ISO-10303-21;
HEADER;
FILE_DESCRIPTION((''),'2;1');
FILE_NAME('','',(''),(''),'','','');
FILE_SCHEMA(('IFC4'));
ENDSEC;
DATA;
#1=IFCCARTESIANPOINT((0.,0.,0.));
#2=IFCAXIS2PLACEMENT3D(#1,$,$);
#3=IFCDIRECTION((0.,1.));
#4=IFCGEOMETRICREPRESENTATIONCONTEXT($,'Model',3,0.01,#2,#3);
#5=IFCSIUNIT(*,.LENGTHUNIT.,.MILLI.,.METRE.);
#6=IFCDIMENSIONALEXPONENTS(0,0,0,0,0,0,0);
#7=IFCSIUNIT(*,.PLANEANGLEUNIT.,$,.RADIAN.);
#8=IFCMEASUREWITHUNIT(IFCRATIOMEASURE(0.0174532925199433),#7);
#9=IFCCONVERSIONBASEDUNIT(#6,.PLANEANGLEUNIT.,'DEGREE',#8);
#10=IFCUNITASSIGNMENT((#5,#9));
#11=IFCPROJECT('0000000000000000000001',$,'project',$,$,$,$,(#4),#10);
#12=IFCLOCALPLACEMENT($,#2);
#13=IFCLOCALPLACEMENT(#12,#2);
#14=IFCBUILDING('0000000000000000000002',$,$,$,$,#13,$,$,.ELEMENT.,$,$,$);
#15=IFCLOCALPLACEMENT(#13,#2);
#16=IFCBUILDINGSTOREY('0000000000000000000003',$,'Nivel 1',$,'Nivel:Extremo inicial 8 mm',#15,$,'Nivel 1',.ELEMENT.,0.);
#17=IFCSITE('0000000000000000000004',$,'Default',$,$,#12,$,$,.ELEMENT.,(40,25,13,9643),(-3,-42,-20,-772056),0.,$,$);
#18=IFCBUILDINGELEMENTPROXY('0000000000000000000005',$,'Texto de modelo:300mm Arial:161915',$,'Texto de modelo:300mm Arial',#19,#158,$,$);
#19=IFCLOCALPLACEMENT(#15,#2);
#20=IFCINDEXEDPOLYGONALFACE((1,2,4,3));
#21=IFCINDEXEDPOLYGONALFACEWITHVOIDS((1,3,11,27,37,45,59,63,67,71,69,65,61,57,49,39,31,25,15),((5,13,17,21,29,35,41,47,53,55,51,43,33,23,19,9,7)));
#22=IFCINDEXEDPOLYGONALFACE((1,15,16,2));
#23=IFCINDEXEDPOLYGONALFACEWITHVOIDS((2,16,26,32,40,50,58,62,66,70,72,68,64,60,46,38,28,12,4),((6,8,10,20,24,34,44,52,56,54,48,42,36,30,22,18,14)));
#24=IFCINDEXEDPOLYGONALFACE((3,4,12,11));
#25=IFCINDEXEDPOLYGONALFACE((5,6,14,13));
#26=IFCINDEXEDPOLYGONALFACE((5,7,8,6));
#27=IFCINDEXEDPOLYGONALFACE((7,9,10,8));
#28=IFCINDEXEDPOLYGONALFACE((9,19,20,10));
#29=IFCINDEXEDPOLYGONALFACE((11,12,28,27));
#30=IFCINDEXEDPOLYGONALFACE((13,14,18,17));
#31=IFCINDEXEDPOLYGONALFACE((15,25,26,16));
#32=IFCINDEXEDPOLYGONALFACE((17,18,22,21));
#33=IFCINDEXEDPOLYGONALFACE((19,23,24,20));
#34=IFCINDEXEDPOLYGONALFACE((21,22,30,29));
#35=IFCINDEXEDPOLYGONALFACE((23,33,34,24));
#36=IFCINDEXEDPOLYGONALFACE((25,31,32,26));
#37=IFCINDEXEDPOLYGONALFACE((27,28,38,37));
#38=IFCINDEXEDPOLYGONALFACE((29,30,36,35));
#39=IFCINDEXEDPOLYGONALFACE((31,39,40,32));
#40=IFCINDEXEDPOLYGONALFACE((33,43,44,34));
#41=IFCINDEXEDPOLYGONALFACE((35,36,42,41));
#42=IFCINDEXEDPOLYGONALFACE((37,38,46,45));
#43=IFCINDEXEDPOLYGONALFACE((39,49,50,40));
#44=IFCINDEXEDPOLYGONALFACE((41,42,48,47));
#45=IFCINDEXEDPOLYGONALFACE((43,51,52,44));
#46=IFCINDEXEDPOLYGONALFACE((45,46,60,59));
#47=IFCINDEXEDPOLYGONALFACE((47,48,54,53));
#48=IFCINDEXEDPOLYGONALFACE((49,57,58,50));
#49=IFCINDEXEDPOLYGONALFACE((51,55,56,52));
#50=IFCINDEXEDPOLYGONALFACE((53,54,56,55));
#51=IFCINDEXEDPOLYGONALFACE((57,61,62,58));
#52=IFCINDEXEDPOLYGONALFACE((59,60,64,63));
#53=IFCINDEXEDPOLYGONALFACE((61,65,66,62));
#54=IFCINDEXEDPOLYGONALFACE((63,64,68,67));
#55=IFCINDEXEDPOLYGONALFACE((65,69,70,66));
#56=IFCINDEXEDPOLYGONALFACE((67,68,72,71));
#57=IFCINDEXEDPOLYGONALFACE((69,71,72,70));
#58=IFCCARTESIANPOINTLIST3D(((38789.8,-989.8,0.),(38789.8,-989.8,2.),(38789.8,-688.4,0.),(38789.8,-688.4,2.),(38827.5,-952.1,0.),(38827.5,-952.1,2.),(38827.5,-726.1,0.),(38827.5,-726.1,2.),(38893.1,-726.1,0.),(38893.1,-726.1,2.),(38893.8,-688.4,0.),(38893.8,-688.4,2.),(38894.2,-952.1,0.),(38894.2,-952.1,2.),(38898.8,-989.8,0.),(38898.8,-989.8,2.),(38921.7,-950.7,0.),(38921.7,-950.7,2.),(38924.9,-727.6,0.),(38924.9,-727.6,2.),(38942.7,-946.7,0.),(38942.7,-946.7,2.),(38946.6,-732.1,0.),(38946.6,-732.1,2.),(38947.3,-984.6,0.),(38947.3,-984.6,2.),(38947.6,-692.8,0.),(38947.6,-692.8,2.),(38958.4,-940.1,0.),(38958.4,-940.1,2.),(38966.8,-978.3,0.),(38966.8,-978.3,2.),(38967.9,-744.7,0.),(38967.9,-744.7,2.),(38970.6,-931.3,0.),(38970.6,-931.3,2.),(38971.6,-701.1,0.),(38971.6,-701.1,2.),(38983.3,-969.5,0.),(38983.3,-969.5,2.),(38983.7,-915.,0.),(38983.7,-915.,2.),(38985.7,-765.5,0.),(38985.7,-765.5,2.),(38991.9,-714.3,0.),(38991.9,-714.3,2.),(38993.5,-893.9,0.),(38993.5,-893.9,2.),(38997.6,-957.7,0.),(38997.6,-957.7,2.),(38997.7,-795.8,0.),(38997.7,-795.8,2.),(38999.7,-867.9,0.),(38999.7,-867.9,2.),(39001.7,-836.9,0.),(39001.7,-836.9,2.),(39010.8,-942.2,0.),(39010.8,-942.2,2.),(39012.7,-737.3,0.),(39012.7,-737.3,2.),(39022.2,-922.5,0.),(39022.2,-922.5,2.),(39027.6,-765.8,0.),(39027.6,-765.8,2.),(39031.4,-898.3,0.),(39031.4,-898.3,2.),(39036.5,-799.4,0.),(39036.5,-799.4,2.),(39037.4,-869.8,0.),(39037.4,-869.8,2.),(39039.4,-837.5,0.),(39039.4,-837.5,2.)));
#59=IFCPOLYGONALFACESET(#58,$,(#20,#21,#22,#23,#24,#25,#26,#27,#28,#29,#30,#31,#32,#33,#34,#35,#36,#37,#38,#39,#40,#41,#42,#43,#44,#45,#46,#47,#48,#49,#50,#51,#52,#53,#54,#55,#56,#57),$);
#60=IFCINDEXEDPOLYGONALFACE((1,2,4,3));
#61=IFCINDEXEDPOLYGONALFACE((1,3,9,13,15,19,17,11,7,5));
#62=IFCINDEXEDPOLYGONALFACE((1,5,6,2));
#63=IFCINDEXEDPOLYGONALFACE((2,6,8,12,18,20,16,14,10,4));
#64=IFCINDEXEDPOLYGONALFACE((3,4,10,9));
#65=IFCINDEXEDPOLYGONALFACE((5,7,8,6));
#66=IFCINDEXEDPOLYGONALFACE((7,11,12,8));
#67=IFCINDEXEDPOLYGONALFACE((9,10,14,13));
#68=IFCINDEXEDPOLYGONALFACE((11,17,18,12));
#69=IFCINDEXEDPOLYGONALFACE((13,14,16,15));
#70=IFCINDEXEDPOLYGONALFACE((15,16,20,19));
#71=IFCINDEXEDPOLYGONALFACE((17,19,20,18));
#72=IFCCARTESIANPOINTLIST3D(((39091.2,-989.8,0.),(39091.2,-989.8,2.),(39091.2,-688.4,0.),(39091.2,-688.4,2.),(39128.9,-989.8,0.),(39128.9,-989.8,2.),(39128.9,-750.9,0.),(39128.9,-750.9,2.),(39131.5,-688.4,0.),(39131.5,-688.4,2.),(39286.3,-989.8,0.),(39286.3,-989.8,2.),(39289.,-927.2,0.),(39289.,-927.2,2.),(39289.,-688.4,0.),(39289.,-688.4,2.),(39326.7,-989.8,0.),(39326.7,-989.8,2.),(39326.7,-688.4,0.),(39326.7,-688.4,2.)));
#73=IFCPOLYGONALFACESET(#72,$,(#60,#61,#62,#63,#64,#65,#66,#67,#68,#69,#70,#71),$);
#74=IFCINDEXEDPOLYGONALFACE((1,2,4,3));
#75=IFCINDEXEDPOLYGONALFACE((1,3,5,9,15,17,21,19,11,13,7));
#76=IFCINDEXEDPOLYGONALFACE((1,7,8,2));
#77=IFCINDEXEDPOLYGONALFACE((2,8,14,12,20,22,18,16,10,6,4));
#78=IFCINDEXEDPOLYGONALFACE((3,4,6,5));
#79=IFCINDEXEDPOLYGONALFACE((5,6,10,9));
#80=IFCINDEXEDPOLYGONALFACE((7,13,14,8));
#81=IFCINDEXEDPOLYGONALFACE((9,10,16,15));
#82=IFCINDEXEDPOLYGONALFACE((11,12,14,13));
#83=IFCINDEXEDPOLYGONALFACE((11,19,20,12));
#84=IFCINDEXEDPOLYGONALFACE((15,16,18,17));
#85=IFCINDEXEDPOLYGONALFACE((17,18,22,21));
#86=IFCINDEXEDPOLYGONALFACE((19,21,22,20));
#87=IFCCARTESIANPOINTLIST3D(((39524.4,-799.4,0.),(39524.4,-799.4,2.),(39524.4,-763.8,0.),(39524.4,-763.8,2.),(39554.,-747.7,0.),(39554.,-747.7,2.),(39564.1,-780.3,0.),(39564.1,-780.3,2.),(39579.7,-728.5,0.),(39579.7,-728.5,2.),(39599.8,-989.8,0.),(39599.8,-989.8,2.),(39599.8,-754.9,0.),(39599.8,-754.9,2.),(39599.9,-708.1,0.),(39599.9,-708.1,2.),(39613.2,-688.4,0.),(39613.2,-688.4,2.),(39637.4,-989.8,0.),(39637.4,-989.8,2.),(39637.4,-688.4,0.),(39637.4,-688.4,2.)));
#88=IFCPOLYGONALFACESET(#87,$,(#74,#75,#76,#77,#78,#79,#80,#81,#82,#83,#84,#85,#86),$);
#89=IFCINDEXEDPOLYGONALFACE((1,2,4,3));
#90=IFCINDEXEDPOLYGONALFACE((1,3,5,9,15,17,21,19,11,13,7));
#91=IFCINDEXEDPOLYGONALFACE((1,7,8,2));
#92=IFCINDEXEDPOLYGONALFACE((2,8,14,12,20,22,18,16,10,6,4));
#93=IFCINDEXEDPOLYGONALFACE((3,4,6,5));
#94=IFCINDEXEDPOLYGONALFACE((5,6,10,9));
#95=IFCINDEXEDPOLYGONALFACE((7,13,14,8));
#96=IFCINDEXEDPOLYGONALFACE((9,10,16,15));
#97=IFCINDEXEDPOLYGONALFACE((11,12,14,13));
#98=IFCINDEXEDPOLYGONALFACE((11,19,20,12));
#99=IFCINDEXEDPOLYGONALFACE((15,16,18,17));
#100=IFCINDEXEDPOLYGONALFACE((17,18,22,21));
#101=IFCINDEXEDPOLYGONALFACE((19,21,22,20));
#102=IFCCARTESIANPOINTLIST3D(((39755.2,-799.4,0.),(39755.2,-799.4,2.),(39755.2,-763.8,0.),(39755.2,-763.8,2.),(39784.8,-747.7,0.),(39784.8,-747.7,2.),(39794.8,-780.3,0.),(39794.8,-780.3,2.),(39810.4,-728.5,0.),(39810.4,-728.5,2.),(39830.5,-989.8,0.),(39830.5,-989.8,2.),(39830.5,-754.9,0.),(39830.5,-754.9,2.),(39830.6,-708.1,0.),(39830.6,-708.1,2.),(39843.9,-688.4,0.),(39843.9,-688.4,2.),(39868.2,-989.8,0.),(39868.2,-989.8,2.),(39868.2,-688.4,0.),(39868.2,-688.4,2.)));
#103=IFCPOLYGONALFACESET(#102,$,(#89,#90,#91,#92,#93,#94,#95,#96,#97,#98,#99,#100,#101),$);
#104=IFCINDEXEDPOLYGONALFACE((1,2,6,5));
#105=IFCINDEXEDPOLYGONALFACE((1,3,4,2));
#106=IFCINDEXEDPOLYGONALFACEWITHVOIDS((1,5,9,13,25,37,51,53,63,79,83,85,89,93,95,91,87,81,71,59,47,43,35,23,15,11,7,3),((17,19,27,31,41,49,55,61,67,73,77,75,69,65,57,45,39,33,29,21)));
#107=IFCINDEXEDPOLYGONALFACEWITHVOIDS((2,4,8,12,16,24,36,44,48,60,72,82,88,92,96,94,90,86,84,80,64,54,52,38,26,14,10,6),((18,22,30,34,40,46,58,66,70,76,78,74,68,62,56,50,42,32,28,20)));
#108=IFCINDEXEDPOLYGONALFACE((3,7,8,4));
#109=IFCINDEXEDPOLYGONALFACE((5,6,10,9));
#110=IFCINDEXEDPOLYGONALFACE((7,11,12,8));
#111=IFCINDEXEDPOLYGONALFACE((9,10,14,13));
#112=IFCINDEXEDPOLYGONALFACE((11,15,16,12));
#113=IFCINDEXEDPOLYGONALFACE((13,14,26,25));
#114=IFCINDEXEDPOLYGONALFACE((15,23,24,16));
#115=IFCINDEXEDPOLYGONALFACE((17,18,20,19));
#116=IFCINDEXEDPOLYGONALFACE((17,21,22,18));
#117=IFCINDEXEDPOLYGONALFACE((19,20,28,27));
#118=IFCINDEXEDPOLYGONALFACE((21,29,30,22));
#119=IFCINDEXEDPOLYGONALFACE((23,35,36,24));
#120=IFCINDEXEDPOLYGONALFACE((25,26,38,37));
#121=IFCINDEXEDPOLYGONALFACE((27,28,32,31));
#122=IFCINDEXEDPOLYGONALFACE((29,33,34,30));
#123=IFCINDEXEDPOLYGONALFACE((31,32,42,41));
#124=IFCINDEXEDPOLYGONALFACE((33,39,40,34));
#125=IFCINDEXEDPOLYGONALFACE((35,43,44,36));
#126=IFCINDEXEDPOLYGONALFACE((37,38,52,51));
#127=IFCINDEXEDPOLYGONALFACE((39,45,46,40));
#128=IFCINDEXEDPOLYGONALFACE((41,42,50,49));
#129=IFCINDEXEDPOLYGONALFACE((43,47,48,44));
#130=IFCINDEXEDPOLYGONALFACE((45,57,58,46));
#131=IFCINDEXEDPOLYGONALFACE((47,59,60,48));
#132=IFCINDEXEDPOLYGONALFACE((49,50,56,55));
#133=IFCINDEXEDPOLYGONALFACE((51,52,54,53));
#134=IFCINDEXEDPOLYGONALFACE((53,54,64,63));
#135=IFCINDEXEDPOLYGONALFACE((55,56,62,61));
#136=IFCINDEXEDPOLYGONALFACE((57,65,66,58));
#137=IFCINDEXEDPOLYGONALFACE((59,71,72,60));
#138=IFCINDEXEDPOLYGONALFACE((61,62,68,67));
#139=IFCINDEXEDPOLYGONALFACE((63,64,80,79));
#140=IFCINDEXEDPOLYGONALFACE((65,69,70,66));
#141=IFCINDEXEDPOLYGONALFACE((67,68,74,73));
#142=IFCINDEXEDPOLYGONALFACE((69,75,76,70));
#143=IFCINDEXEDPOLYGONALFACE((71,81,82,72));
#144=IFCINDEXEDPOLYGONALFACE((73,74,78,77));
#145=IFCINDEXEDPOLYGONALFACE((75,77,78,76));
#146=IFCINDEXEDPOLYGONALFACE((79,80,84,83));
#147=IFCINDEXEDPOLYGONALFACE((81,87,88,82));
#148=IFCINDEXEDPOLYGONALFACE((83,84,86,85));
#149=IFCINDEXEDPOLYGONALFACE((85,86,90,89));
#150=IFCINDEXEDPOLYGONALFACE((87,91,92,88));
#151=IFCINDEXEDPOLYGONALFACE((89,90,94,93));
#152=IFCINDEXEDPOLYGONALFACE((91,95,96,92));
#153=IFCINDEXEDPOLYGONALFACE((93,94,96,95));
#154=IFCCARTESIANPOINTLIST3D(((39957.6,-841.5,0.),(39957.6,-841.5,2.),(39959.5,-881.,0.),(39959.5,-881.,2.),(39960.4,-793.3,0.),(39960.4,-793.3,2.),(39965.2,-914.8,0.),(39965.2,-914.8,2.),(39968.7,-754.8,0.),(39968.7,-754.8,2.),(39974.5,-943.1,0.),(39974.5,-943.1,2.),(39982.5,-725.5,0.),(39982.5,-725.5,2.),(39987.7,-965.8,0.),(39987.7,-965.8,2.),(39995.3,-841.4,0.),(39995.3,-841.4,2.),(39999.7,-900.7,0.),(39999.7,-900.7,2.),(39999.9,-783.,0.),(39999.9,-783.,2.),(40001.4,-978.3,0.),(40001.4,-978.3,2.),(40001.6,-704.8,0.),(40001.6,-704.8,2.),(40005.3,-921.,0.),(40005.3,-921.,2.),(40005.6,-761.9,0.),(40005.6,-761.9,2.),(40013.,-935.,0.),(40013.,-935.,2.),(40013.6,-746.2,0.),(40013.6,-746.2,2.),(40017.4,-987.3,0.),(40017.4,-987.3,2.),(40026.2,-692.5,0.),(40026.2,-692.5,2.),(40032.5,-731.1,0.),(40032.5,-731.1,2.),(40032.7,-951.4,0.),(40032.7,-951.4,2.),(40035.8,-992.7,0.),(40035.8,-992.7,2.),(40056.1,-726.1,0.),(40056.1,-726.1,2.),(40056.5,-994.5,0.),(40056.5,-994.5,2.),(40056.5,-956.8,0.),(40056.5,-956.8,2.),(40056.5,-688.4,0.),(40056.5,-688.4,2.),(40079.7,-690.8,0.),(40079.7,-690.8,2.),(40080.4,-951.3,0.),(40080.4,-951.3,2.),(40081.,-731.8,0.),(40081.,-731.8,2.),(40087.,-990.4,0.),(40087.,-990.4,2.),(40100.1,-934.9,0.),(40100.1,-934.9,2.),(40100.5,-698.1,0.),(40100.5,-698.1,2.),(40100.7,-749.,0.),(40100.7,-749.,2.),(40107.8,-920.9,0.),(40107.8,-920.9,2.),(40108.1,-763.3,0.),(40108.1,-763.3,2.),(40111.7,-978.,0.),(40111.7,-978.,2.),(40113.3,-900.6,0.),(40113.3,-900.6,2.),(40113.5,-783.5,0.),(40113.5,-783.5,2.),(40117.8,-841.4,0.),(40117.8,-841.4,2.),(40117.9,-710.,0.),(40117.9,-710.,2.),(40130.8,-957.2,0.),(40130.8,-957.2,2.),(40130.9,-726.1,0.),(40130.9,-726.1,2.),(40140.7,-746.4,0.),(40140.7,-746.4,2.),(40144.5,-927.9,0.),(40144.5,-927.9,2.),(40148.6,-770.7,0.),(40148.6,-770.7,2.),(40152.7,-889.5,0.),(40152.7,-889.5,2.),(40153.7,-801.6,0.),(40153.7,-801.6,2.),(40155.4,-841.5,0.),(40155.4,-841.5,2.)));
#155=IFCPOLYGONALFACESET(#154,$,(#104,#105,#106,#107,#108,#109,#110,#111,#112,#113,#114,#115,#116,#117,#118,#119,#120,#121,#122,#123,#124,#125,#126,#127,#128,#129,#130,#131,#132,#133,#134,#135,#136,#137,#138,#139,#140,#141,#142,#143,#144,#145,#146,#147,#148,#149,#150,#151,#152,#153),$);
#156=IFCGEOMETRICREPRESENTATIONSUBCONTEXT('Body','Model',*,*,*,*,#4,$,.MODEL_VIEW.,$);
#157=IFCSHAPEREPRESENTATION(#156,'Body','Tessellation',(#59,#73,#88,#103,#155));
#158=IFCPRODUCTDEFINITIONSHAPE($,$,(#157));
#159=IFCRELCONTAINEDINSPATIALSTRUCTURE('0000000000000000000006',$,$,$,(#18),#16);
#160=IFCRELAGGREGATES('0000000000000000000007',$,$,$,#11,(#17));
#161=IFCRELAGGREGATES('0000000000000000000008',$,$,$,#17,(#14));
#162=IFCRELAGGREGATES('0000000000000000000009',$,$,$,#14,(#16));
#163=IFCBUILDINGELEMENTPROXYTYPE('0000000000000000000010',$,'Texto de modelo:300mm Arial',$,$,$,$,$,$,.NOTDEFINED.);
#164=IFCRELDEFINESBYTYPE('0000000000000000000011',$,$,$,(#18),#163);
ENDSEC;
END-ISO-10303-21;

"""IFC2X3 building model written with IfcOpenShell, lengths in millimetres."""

from ifc_helpers import new_model, entity, si_unit, converted_unit, direction, frame, origin, place, context, subcontext, project, spatial, polyline, outline, extrude, type_object, element, save


model = new_model("IFC2X3")

# Units and contexts
model_context = context("Model", 3, precision=0.01, world=origin(), true_north=direction((0.0, 1.0)))
body_context = subcontext(model_context, "Body", "Model", "MODEL_VIEW")
ifc_project = project(units=[si_unit("LENGTHUNIT", "METRE", prefix="MILLI"), converted_unit("PLANEANGLEUNIT", "DEGREE", entity("IfcRatioMeasure", 0.0174532925199433), si_unit("PLANEANGLEUNIT", "RADIAN"), dimensions=[0, 0, 0, 0, 0, 0, 0])], contexts=[model_context])

# Site, building, storey
site_placement = place(None, origin())
site = spatial("IfcSite", under=ifc_project, at=site_placement, Name="Default", CompositionType="ELEMENT", RefLatitude=(40, 25, 13, 9643), RefLongitude=(-3, -42, -20, -772056), RefElevation=0.0)
building_placement = place(site_placement, origin())
building = spatial("IfcBuilding", under=site, at=building_placement, CompositionType="ELEMENT")
storey_placement = place(building_placement, origin())
storey = spatial("IfcBuildingStorey", under=building, at=storey_placement, Name="Nivel 1", ObjectType="Nivel:Extremo inicial 8 mm", LongName="Nivel 1", CompositionType="ELEMENT", Elevation=0.0)

# Building element proxy
building_element_proxy_type_1 = type_object("IfcBuildingElementProxyType", Name="Texto de modelo:300mm Arial", PredefinedType="NOTDEFINED")
proxy_1_placement = place(storey_placement, frame((38789.8, -994.5, 0.0)))
element("IfcBuildingElementProxy", 1, at=proxy_1_placement, inside=storey, type_object=building_element_proxy_type_1, Name="Texto de modelo:300mm Arial:161915", ObjectType="Texto de modelo:300mm Arial", context=body_context, shape_type="SweptSolid", body=[
    extrude(outline(polyline([(-178.4, -141.0), (-69.4, -141.0), (-21.0, -135.8), (-1.4, -129.5), (15.0, -120.7), (29.4, -108.9), (42.6, -93.4), (54.0, -73.7), (63.2, -49.5), (69.2, -21.0), (71.2, 11.3), (68.2, 49.4), (59.3, 83.0), (44.5, 111.5), (23.7, 134.5), (3.4, 147.7), (-20.6, 156.1), (-74.4, 160.4), (-178.4, 160.4), (-178.4, -141.0)]), holes=[polyline([(-140.7, -103.3), (-140.7, 122.7), (-75.1, 122.7), (-43.3, 121.2), (-21.7, 116.7), (-0.4, 104.1), (17.4, 83.3), (29.5, 53.0), (33.5, 11.9), (31.5, -19.1), (25.3, -45.1), (15.5, -66.2), (2.4, -82.5), (-9.8, -91.3), (-25.6, -97.9), (-46.5, -101.9), (-74.1, -103.3), (-140.7, -103.3)])]), frame((178.4, 145.7, 0.0)), (0.0, 0.0, 1.0), 2.0),
    extrude(outline(polyline([(-117.7, -150.7), (-80.1, -150.7), (-80.1, 88.1), (77.4, -150.7), (117.7, -150.7), (117.7, 150.7), (80.1, 150.7), (80.1, -88.1), (-77.4, 150.7), (-117.7, 150.7), (-117.7, -150.7)])), frame((419.1, 155.4, 0.0)), (0.0, 0.0, 1.0), 2.0),
    extrude(outline(polyline([(-204.4, -52.5), (97.0, -52.5), (97.0, -28.2), (77.2, -14.9), (56.9, 5.3), (37.7, 30.9), (21.6, 60.5), (-14.0, 60.5), (5.0, 20.8), (30.4, -14.9), (-204.4, -14.9), (-204.4, -52.5)])), frame((795.1, 209.1, 0.0), z_axis=(0.0, 0.0, 1.0), x_axis=(0.0, 1.0, 0.0)), (0.0, 0.0, 1.0), 2.0),
    extrude(outline(polyline([(-204.4, -52.5), (97.0, -52.5), (97.0, -28.2), (77.2, -14.9), (56.9, 5.3), (37.7, 30.9), (21.6, 60.5), (-14.0, 60.5), (5.0, 20.8), (30.4, -14.9), (-204.4, -14.9), (-204.4, -52.5)])), frame((1025.8, 209.1, 0.0), z_axis=(0.0, 0.0, 1.0), x_axis=(0.0, 1.0, 0.0)), (0.0, 0.0, 1.0), 2.0),
    extrude(outline(polyline([(-5.6, -99.5), (33.9, -99.5), (68.0, -95.5), (96.7, -87.5), (120.0, -75.5), (133.2, -62.4), (142.9, -46.8), (149.1, -28.7), (151.9, -8.0), (149.2, 22.6), (138.0, 47.8), (118.2, 67.9), (89.5, 82.9), (51.6, 93.0), (3.8, 98.0), (-36.2, 98.2), (-67.3, 94.5), (-91.9, 87.9), (-112.6, 79.0), (-129.4, 66.8), (-142.0, 50.0), (-150.3, 29.6), (-153.8, 6.5), (-151.2, -23.9), (-140.1, -49.1), (-120.3, -69.2), (-91.7, -84.4), (-53.6, -94.5), (-5.6, -99.5)]), holes=[polyline([(-3.9, -61.9), (-62.1, -54.6), (-82.9, -47.9), (-98.1, -39.2), (-112.3, -19.5), (-116.2, 4.3), (-109.3, 28.9), (-91.2, 47.7), (-76.5, 54.5), (-56.1, 58.9), (1.9, 60.4), (60.8, 53.2), (80.8, 46.7), (94.5, 38.3), (109.9, 17.8), (114.3, -6.3), (107.7, -29.8), (90.4, -48.7), (76.0, -55.8), (55.5, -60.3), (-3.9, -61.9)])]), frame((1267.5, 152.1, 0.0), z_axis=(0.0, 0.0, 1.0), x_axis=(0.047515, -0.998871, 0.0)), (0.0, 0.0, 1.0), 2.0),
])

save(model, "model.ifc")
